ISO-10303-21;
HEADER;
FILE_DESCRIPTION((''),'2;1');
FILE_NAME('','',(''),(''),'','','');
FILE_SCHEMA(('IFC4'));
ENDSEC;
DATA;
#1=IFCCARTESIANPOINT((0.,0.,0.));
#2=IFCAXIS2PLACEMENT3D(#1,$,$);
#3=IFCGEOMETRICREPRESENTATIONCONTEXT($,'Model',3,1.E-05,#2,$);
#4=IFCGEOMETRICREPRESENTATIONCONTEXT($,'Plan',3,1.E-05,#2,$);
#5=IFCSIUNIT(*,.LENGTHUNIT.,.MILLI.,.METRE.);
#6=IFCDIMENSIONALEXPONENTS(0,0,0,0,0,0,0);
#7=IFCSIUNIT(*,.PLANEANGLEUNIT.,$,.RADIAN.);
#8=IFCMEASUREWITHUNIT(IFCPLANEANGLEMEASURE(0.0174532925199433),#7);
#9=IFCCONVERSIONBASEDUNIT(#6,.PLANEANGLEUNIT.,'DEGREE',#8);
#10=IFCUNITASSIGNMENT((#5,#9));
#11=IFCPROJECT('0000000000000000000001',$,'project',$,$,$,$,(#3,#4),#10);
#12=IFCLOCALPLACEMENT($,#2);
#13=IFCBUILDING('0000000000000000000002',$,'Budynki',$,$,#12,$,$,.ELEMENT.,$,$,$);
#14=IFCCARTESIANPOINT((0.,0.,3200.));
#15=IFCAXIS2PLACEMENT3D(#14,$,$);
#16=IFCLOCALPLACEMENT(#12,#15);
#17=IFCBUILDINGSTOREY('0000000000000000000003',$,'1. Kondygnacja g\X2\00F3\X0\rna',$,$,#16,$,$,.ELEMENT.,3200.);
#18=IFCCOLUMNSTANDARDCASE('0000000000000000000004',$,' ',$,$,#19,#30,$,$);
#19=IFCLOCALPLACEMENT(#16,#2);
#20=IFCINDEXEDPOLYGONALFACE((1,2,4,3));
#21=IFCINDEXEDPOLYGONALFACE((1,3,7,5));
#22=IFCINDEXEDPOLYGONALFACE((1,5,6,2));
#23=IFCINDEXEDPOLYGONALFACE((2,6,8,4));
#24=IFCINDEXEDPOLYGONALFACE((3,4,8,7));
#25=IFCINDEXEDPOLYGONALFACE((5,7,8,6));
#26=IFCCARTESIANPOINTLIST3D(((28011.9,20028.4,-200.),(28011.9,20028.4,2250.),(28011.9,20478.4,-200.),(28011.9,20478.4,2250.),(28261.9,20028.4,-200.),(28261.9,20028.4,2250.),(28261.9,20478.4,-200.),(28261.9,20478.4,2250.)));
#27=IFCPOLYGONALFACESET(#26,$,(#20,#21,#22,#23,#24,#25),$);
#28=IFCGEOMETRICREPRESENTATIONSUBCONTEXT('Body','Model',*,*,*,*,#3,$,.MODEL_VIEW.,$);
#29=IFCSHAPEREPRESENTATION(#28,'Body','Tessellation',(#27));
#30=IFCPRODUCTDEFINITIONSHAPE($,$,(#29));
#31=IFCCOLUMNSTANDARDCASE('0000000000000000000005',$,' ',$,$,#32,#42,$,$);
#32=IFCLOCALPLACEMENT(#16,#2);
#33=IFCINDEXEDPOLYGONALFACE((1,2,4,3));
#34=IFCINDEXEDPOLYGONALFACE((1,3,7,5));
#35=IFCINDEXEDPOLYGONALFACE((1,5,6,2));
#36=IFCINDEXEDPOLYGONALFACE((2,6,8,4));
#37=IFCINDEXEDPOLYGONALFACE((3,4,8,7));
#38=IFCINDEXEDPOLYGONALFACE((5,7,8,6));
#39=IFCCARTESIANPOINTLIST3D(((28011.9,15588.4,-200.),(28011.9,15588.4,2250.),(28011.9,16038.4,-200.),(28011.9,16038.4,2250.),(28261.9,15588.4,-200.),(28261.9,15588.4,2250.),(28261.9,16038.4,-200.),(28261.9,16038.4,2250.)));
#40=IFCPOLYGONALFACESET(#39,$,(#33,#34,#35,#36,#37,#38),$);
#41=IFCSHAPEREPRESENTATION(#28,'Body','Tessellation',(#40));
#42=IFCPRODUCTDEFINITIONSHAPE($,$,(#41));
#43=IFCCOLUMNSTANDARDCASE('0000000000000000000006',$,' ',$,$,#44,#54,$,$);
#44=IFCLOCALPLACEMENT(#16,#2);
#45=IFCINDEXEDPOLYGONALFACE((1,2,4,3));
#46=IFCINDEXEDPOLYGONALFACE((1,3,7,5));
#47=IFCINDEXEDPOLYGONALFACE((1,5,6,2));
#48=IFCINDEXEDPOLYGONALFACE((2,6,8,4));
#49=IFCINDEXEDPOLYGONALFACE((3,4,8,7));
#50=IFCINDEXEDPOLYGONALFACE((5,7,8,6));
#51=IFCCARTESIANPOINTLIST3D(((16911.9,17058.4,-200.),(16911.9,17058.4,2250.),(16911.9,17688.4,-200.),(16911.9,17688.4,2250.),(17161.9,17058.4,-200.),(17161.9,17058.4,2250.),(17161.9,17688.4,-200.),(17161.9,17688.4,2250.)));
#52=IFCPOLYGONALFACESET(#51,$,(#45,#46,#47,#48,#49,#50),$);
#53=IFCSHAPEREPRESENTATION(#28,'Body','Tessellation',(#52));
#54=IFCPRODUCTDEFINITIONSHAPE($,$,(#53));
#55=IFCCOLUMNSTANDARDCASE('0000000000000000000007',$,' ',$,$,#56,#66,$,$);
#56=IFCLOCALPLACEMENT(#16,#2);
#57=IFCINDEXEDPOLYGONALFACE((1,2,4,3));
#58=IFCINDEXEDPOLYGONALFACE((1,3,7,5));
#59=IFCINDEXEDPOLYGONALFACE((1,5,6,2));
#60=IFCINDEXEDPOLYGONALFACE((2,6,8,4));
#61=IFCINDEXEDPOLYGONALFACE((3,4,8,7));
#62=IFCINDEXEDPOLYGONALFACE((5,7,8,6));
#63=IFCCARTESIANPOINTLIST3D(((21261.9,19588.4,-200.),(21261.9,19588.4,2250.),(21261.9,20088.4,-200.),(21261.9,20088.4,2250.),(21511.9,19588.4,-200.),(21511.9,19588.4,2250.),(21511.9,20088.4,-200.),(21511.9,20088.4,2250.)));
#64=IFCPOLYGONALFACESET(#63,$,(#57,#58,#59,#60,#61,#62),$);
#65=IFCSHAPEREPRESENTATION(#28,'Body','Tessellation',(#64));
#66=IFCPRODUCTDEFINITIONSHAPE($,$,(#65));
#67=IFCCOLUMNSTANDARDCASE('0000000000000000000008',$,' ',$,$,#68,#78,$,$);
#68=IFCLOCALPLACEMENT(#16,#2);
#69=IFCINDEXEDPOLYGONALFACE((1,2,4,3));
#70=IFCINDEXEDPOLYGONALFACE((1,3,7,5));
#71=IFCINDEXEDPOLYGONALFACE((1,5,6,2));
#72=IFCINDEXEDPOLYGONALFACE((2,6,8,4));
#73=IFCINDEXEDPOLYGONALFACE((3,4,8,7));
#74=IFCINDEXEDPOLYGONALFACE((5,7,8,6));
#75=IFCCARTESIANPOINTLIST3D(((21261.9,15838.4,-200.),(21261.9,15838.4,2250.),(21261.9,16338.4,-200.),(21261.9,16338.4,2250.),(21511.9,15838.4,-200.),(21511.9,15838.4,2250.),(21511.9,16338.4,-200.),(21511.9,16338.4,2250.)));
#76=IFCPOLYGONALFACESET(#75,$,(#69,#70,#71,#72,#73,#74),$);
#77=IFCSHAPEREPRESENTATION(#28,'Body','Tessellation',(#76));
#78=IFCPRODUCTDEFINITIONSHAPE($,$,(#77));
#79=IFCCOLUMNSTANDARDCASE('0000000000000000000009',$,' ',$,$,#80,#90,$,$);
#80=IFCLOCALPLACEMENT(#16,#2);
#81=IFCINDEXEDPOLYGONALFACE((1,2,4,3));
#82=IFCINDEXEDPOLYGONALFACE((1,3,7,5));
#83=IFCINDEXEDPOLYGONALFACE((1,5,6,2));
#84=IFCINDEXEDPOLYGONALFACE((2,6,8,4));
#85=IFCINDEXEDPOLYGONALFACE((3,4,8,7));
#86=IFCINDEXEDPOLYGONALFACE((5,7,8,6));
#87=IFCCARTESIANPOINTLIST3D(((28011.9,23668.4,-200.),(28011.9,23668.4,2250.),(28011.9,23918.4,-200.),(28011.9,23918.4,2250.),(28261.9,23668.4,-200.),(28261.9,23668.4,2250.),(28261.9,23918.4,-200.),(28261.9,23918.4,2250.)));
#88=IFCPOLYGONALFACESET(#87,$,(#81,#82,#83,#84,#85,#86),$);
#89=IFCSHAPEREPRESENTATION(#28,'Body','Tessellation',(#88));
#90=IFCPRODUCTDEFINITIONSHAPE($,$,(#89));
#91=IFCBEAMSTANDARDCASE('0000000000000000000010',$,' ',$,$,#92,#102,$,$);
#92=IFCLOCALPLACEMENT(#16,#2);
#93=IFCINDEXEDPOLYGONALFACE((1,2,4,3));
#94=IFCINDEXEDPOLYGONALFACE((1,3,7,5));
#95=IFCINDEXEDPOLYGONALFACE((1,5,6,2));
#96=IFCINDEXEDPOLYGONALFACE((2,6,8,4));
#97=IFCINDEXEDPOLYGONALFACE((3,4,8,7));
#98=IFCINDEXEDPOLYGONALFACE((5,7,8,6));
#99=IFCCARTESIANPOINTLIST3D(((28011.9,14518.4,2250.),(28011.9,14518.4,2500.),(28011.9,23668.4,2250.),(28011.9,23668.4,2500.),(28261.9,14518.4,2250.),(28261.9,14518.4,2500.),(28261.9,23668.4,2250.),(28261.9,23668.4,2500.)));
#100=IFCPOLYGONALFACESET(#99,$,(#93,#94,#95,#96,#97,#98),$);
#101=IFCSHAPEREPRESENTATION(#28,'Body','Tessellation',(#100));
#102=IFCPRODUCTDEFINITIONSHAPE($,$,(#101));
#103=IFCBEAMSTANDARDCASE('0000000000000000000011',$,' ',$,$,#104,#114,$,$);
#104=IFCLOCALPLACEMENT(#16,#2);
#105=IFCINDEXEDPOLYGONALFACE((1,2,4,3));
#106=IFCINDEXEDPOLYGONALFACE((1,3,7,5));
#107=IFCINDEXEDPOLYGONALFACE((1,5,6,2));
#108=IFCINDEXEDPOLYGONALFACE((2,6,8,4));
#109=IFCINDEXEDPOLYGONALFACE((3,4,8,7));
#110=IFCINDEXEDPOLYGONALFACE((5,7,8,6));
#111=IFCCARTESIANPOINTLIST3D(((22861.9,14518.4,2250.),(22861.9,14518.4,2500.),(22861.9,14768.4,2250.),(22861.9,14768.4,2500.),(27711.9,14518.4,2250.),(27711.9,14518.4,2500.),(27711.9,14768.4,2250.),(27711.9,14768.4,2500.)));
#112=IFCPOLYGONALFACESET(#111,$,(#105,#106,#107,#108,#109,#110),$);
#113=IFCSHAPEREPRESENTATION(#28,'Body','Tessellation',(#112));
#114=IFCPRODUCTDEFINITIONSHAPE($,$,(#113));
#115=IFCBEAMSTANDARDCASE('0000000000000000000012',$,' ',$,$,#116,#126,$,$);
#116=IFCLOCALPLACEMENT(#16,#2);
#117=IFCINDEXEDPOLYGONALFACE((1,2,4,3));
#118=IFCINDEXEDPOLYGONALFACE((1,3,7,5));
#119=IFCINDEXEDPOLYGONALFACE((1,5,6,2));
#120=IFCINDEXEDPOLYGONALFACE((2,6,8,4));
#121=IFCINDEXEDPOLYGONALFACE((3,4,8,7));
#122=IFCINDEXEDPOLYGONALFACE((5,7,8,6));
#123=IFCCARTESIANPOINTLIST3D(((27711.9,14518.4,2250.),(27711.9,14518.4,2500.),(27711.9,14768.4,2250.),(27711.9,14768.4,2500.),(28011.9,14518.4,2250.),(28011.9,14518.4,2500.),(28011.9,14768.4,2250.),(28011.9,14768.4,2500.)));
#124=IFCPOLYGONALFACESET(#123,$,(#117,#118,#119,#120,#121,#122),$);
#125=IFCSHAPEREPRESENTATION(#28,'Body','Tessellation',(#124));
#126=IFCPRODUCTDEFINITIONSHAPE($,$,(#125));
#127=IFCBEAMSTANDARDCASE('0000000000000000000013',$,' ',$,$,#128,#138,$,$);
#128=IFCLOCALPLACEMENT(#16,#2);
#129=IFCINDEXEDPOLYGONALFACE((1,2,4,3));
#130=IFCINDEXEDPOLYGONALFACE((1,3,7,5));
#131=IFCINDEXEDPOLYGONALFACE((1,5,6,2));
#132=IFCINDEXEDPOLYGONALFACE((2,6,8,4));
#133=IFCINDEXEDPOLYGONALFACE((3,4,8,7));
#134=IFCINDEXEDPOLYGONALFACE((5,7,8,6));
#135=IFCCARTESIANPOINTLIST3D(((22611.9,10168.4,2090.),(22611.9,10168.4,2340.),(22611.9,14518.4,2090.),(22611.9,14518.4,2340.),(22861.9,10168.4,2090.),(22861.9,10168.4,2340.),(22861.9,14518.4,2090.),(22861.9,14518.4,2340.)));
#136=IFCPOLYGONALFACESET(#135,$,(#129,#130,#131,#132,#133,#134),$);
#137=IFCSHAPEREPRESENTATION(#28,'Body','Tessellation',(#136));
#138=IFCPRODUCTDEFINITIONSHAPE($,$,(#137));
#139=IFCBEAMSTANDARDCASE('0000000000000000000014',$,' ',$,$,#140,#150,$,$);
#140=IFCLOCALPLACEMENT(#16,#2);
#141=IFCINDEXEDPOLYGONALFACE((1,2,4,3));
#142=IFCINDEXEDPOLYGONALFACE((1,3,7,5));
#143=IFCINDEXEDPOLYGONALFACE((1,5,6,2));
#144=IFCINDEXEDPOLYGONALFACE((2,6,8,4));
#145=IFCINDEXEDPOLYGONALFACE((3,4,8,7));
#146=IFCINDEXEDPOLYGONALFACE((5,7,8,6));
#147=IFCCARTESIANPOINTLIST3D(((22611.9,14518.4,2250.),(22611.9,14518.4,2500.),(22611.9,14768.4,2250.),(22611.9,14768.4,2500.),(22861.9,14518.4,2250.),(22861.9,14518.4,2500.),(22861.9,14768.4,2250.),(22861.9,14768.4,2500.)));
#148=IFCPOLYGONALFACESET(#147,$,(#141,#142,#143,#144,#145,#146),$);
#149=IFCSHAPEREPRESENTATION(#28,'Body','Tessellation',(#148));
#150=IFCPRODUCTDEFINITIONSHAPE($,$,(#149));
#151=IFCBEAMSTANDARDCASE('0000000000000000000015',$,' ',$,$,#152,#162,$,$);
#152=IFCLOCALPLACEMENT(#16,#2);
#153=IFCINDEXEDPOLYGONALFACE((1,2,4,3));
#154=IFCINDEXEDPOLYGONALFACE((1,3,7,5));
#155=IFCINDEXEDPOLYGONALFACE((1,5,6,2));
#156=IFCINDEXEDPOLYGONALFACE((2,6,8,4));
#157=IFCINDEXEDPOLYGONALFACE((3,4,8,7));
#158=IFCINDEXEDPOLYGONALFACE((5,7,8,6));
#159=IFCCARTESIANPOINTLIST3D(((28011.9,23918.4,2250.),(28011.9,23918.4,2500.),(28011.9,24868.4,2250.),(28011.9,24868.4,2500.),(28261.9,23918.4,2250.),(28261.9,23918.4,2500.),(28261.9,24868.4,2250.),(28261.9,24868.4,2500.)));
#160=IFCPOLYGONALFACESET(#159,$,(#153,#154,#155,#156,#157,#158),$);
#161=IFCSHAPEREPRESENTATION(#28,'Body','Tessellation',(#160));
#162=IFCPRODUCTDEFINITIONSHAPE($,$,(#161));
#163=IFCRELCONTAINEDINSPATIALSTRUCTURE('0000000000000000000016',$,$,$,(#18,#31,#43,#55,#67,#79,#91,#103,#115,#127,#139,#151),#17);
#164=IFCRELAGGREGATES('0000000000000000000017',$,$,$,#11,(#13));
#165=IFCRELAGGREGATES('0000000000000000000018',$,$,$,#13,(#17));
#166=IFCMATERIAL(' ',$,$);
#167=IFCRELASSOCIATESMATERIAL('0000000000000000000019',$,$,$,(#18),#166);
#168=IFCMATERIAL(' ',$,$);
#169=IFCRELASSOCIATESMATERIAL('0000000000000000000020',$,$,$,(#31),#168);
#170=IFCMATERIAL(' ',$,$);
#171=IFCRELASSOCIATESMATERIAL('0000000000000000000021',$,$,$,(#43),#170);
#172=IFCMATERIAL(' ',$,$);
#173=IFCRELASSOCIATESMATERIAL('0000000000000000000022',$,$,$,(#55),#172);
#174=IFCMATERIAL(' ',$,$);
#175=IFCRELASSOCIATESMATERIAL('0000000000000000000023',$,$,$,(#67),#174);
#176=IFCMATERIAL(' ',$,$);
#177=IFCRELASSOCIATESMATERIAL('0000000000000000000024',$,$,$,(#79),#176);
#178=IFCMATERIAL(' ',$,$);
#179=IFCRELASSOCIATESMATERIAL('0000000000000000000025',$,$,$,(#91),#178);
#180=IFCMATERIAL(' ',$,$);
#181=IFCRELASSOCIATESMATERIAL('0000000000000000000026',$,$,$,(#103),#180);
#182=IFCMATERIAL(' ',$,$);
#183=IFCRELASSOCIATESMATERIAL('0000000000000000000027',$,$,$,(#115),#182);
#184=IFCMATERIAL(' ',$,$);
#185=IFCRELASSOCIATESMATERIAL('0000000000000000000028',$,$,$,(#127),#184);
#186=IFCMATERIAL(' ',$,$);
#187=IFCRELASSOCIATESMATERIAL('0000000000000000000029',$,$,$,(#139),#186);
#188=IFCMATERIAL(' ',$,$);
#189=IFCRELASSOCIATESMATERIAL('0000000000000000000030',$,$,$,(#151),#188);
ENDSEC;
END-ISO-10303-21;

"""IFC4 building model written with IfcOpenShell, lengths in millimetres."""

from ifc_helpers import new_model, entity, si_unit, converted_unit, frame, frame_2d, origin, place, context, subcontext, project, spatial, rectangle, extrude, material, material_profile, profile_set, profile_usage, element, save


model = new_model("IFC4")

# Units and contexts
model_context = context("Model", 3, precision=1e-05, world=origin())
plan_context = context("Plan", 3, precision=1e-05, world=origin())
body_context = subcontext(model_context, "Body", "Model", "MODEL_VIEW")
ifc_project = project(units=[si_unit("LENGTHUNIT", "METRE", prefix="MILLI"), converted_unit("PLANEANGLEUNIT", "DEGREE", entity("IfcPlaneAngleMeasure", 0.0174532925199433), si_unit("PLANEANGLEUNIT", "RADIAN"), dimensions=[0, 0, 0, 0, 0, 0, 0])], contexts=[model_context, plan_context])

# Building, storey
building_placement = place(None, origin())
building = spatial("IfcBuilding", under=ifc_project, at=building_placement, Name="Budynki", CompositionType="ELEMENT")
storey_placement = place(building_placement, frame((0.0, 0.0, 3200.0)))
storey = spatial("IfcBuildingStorey", under=building, at=storey_placement, Name="1. Kondygnacja górna", CompositionType="ELEMENT", Elevation=3200.0)

# Columns
ifc_material_1 = material(Name=" ")
ifc_material_profile_1 = material_profile(ifc_material_1, rectangle(XDim=450.0, YDim=250.0, at=frame_2d((-125.0, 225.0), x_axis=(0.0, 1.0))))
ifc_profile_set_1 = profile_set([ifc_material_profile_1])
ifc_profile_usage_1 = profile_usage(ifc_profile_set_1)
column_1_placement = place(storey_placement, frame((28011.9, 20028.4, -200.0)))
element("IfcColumnStandardCase", 1, at=column_1_placement, inside=storey, material=ifc_profile_usage_1, Name=" ", context=body_context, shape_type="SweptSolid", body=[
    extrude(rectangle(XDim=450.0, YDim=250.0, at=frame_2d((-125.0, 225.0), x_axis=(0.0, 1.0))), frame((250.0, 0.0, 0.0), z_axis=(0.0, 0.0, 1.0), x_axis=(1.0, 0.0, 0.0)), (0.0, 0.0, 1.0), 2450.0),
])
ifc_material_2 = material(Name=" ")
ifc_material_profile_2 = material_profile(ifc_material_2, rectangle(XDim=450.0, YDim=250.0, at=frame_2d((-125.0, 225.0), x_axis=(0.0, 1.0))))
ifc_profile_set_2 = profile_set([ifc_material_profile_2])
ifc_profile_usage_2 = profile_usage(ifc_profile_set_2)
column_2_placement = place(storey_placement, frame((28011.9, 15588.4, -200.0)))
element("IfcColumnStandardCase", 2, at=column_2_placement, inside=storey, material=ifc_profile_usage_2, Name=" ", context=body_context, shape_type="SweptSolid", body=[
    extrude(rectangle(XDim=450.0, YDim=250.0, at=frame_2d((-125.0, 225.0), x_axis=(0.0, 1.0))), frame((250.0, 0.0, 0.0), z_axis=(0.0, 0.0, 1.0), x_axis=(1.0, 0.0, 0.0)), (0.0, 0.0, 1.0), 2450.0),
])
ifc_material_3 = material(Name=" ")
ifc_material_profile_3 = material_profile(ifc_material_3, rectangle(XDim=630.0, YDim=250.0, at=frame_2d((-125.0, 315.0), x_axis=(0.0, 1.0))))
ifc_profile_set_3 = profile_set([ifc_material_profile_3])
ifc_profile_usage_3 = profile_usage(ifc_profile_set_3)
column_3_placement = place(storey_placement, frame((16911.9, 17058.4, -200.0)))
element("IfcColumnStandardCase", 3, at=column_3_placement, inside=storey, material=ifc_profile_usage_3, Name=" ", context=body_context, shape_type="SweptSolid", body=[
    extrude(rectangle(XDim=630.0, YDim=250.0, at=frame_2d((-125.0, 315.0), x_axis=(0.0, 1.0))), frame((250.0, 0.0, 0.0), z_axis=(0.0, 0.0, 1.0), x_axis=(1.0, 0.0, 0.0)), (0.0, 0.0, 1.0), 2450.0),
])
ifc_material_4 = material(Name=" ")
ifc_material_profile_4 = material_profile(ifc_material_4, rectangle(XDim=500.0, YDim=250.0, at=frame_2d((-125.0, 250.0), x_axis=(0.0, 1.0))))
ifc_profile_set_4 = profile_set([ifc_material_profile_4])
ifc_profile_usage_4 = profile_usage(ifc_profile_set_4)
column_4_placement = place(storey_placement, frame((21261.9, 19588.4, -200.0)))
element("IfcColumnStandardCase", 4, at=column_4_placement, inside=storey, material=ifc_profile_usage_4, Name=" ", context=body_context, shape_type="SweptSolid", body=[
    extrude(rectangle(XDim=500.0, YDim=250.0, at=frame_2d((-125.0, 250.0), x_axis=(0.0, 1.0))), frame((250.0, 0.0, 0.0), z_axis=(0.0, 0.0, 1.0), x_axis=(1.0, 0.0, 0.0)), (0.0, 0.0, 1.0), 2450.0),
])
ifc_material_5 = material(Name=" ")
ifc_material_profile_5 = material_profile(ifc_material_5, rectangle(XDim=500.0, YDim=250.0, at=frame_2d((-125.0, 250.0), x_axis=(0.0, 1.0))))
ifc_profile_set_5 = profile_set([ifc_material_profile_5])
ifc_profile_usage_5 = profile_usage(ifc_profile_set_5)
column_5_placement = place(storey_placement, frame((21261.9, 15838.4, -200.0)))
element("IfcColumnStandardCase", 5, at=column_5_placement, inside=storey, material=ifc_profile_usage_5, Name=" ", context=body_context, shape_type="SweptSolid", body=[
    extrude(rectangle(XDim=500.0, YDim=250.0, at=frame_2d((-125.0, 250.0), x_axis=(0.0, 1.0))), frame((250.0, 0.0, 0.0), z_axis=(0.0, 0.0, 1.0), x_axis=(1.0, 0.0, 0.0)), (0.0, 0.0, 1.0), 2450.0),
])
ifc_material_6 = material(Name=" ")
ifc_material_profile_6 = material_profile(ifc_material_6, rectangle(XDim=250.0, YDim=250.0, at=frame_2d((125.0, -125.0), x_axis=(0.0, -1.0))))
ifc_profile_set_6 = profile_set([ifc_material_profile_6])
ifc_profile_usage_6 = profile_usage(ifc_profile_set_6)
column_6_placement = place(storey_placement, frame((28011.9, 23668.4, -200.0)))
element("IfcColumnStandardCase", 6, at=column_6_placement, inside=storey, material=ifc_profile_usage_6, Name=" ", context=body_context, shape_type="SweptSolid", body=[
    extrude(rectangle(XDim=250.0, YDim=250.0, at=frame_2d((125.0, -125.0), x_axis=(0.0, -1.0))), frame((0.0, 250.0, 0.0), z_axis=(0.0, 0.0, 1.0), x_axis=(1.0, 0.0, 0.0)), (0.0, 0.0, 1.0), 2450.0),
])

# Beams
ifc_material_7 = material(Name=" ")
ifc_material_profile_7 = material_profile(ifc_material_7, rectangle(XDim=250.0, YDim=250.0, at=frame_2d((125.0, -125.0), x_axis=(0.0, 1.0))))
ifc_profile_set_7 = profile_set([ifc_material_profile_7])
ifc_profile_usage_7 = profile_usage(ifc_profile_set_7)
beam_1_placement = place(storey_placement, frame((28261.9, 14518.4, 2250.0), z_axis=(0.0, 0.0, 1.0), x_axis=(0.0, 1.0, 0.0)))
element("IfcBeamStandardCase", 7, at=beam_1_placement, inside=storey, material=ifc_profile_usage_7, Name=" ", context=body_context, shape_type="SweptSolid", body=[
    extrude(rectangle(XDim=250.0, YDim=250.0, at=frame_2d((125.0, -125.0), x_axis=(0.0, 1.0))), frame((0.0, 0.0, 0.0), z_axis=(1.0, 0.0, 0.0), x_axis=(0.0, 0.0, 1.0)), (0.0, 0.0, 1.0), 9150.0),
])
ifc_material_8 = material(Name=" ")
ifc_material_profile_8 = material_profile(ifc_material_8, rectangle(XDim=250.0, YDim=250.0, at=frame_2d((125.0, -125.0), x_axis=(0.0, 1.0))))
ifc_profile_set_8 = profile_set([ifc_material_profile_8])
ifc_profile_usage_8 = profile_usage(ifc_profile_set_8)
beam_2_placement = place(storey_placement, frame((22861.9, 14518.4, 2250.0), z_axis=(0.0, 0.0, 1.0), x_axis=(1.0, 0.0, 0.0)))
element("IfcBeamStandardCase", 8, at=beam_2_placement, inside=storey, material=ifc_profile_usage_8, Name=" ", context=body_context, shape_type="SweptSolid", body=[
    extrude(rectangle(XDim=250.0, YDim=250.0, at=frame_2d((125.0, -125.0), x_axis=(0.0, 1.0))), frame((0.0, 0.0, 0.0), z_axis=(1.0, 0.0, 0.0), x_axis=(0.0, 0.0, 1.0)), (0.0, 0.0, 1.0), 4850.0),
])
ifc_material_9 = material(Name=" ")
ifc_material_profile_9 = material_profile(ifc_material_9, rectangle(XDim=250.0, YDim=250.0, at=frame_2d((125.0, -125.0), x_axis=(0.0, 1.0))))
ifc_profile_set_9 = profile_set([ifc_material_profile_9])
ifc_profile_usage_9 = profile_usage(ifc_profile_set_9)
beam_3_placement = place(storey_placement, frame((27711.9, 14518.4, 2250.0), z_axis=(0.0, 0.0, 1.0), x_axis=(1.0, 0.0, 0.0)))
element("IfcBeamStandardCase", 9, at=beam_3_placement, inside=storey, material=ifc_profile_usage_9, Name=" ", context=body_context, shape_type="SweptSolid", body=[
    extrude(rectangle(XDim=250.0, YDim=250.0, at=frame_2d((125.0, -125.0), x_axis=(0.0, 1.0))), frame((0.0, 0.0, 0.0), z_axis=(1.0, 0.0, 0.0), x_axis=(0.0, 0.0, 1.0)), (0.0, 0.0, 1.0), 300.0),
])
ifc_material_10 = material(Name=" ")
ifc_material_profile_10 = material_profile(ifc_material_10, rectangle(XDim=250.0, YDim=250.0, at=frame_2d((125.0, -125.0), x_axis=(0.0, 1.0))))
ifc_profile_set_10 = profile_set([ifc_material_profile_10])
ifc_profile_usage_10 = profile_usage(ifc_profile_set_10)
beam_4_placement = place(storey_placement, frame((22611.9, 14518.4, 2090.0), z_axis=(0.0, 0.0, 1.0), x_axis=(0.0, -1.0, 0.0)))
element("IfcBeamStandardCase", 10, at=beam_4_placement, inside=storey, material=ifc_profile_usage_10, Name=" ", context=body_context, shape_type="SweptSolid", body=[
    extrude(rectangle(XDim=250.0, YDim=250.0, at=frame_2d((125.0, -125.0), x_axis=(0.0, 1.0))), frame((0.0, 0.0, 0.0), z_axis=(1.0, 0.0, 0.0), x_axis=(0.0, 0.0, 1.0)), (0.0, 0.0, 1.0), 4350.0),
])
ifc_material_11 = material(Name=" ")
ifc_material_profile_11 = material_profile(ifc_material_11, rectangle(XDim=250.0, YDim=250.0, at=frame_2d((125.0, -125.0), x_axis=(0.0, 1.0))))
ifc_profile_set_11 = profile_set([ifc_material_profile_11])
ifc_profile_usage_11 = profile_usage(ifc_profile_set_11)
beam_5_placement = place(storey_placement, frame((22611.9, 14518.4, 2250.0), z_axis=(0.0, 0.0, 1.0), x_axis=(1.0, 0.0, 0.0)))
element("IfcBeamStandardCase", 11, at=beam_5_placement, inside=storey, material=ifc_profile_usage_11, Name=" ", context=body_context, shape_type="SweptSolid", body=[
    extrude(rectangle(XDim=250.0, YDim=250.0, at=frame_2d((125.0, -125.0), x_axis=(0.0, 1.0))), frame((0.0, 0.0, 0.0), z_axis=(1.0, 0.0, 0.0), x_axis=(0.0, 0.0, 1.0)), (0.0, 0.0, 1.0), 250.0),
])
ifc_material_12 = material(Name=" ")
ifc_material_profile_12 = material_profile(ifc_material_12, rectangle(XDim=250.0, YDim=250.0, at=frame_2d((125.0, -125.0), x_axis=(0.0, 1.0))))
ifc_profile_set_12 = profile_set([ifc_material_profile_12])
ifc_profile_usage_12 = profile_usage(ifc_profile_set_12)
beam_6_placement = place(storey_placement, frame((28011.9, 24868.4, 2250.0), z_axis=(0.0, 0.0, 1.0), x_axis=(0.0, -1.0, 0.0)))
element("IfcBeamStandardCase", 12, at=beam_6_placement, inside=storey, material=ifc_profile_usage_12, Name=" ", context=body_context, shape_type="SweptSolid", body=[
    extrude(rectangle(XDim=250.0, YDim=250.0, at=frame_2d((125.0, -125.0), x_axis=(0.0, 1.0))), frame((0.0, 0.0, 0.0), z_axis=(1.0, 0.0, 0.0), x_axis=(0.0, 0.0, 1.0)), (0.0, 0.0, 1.0), 950.0),
])

save(model, "model.ifc")
